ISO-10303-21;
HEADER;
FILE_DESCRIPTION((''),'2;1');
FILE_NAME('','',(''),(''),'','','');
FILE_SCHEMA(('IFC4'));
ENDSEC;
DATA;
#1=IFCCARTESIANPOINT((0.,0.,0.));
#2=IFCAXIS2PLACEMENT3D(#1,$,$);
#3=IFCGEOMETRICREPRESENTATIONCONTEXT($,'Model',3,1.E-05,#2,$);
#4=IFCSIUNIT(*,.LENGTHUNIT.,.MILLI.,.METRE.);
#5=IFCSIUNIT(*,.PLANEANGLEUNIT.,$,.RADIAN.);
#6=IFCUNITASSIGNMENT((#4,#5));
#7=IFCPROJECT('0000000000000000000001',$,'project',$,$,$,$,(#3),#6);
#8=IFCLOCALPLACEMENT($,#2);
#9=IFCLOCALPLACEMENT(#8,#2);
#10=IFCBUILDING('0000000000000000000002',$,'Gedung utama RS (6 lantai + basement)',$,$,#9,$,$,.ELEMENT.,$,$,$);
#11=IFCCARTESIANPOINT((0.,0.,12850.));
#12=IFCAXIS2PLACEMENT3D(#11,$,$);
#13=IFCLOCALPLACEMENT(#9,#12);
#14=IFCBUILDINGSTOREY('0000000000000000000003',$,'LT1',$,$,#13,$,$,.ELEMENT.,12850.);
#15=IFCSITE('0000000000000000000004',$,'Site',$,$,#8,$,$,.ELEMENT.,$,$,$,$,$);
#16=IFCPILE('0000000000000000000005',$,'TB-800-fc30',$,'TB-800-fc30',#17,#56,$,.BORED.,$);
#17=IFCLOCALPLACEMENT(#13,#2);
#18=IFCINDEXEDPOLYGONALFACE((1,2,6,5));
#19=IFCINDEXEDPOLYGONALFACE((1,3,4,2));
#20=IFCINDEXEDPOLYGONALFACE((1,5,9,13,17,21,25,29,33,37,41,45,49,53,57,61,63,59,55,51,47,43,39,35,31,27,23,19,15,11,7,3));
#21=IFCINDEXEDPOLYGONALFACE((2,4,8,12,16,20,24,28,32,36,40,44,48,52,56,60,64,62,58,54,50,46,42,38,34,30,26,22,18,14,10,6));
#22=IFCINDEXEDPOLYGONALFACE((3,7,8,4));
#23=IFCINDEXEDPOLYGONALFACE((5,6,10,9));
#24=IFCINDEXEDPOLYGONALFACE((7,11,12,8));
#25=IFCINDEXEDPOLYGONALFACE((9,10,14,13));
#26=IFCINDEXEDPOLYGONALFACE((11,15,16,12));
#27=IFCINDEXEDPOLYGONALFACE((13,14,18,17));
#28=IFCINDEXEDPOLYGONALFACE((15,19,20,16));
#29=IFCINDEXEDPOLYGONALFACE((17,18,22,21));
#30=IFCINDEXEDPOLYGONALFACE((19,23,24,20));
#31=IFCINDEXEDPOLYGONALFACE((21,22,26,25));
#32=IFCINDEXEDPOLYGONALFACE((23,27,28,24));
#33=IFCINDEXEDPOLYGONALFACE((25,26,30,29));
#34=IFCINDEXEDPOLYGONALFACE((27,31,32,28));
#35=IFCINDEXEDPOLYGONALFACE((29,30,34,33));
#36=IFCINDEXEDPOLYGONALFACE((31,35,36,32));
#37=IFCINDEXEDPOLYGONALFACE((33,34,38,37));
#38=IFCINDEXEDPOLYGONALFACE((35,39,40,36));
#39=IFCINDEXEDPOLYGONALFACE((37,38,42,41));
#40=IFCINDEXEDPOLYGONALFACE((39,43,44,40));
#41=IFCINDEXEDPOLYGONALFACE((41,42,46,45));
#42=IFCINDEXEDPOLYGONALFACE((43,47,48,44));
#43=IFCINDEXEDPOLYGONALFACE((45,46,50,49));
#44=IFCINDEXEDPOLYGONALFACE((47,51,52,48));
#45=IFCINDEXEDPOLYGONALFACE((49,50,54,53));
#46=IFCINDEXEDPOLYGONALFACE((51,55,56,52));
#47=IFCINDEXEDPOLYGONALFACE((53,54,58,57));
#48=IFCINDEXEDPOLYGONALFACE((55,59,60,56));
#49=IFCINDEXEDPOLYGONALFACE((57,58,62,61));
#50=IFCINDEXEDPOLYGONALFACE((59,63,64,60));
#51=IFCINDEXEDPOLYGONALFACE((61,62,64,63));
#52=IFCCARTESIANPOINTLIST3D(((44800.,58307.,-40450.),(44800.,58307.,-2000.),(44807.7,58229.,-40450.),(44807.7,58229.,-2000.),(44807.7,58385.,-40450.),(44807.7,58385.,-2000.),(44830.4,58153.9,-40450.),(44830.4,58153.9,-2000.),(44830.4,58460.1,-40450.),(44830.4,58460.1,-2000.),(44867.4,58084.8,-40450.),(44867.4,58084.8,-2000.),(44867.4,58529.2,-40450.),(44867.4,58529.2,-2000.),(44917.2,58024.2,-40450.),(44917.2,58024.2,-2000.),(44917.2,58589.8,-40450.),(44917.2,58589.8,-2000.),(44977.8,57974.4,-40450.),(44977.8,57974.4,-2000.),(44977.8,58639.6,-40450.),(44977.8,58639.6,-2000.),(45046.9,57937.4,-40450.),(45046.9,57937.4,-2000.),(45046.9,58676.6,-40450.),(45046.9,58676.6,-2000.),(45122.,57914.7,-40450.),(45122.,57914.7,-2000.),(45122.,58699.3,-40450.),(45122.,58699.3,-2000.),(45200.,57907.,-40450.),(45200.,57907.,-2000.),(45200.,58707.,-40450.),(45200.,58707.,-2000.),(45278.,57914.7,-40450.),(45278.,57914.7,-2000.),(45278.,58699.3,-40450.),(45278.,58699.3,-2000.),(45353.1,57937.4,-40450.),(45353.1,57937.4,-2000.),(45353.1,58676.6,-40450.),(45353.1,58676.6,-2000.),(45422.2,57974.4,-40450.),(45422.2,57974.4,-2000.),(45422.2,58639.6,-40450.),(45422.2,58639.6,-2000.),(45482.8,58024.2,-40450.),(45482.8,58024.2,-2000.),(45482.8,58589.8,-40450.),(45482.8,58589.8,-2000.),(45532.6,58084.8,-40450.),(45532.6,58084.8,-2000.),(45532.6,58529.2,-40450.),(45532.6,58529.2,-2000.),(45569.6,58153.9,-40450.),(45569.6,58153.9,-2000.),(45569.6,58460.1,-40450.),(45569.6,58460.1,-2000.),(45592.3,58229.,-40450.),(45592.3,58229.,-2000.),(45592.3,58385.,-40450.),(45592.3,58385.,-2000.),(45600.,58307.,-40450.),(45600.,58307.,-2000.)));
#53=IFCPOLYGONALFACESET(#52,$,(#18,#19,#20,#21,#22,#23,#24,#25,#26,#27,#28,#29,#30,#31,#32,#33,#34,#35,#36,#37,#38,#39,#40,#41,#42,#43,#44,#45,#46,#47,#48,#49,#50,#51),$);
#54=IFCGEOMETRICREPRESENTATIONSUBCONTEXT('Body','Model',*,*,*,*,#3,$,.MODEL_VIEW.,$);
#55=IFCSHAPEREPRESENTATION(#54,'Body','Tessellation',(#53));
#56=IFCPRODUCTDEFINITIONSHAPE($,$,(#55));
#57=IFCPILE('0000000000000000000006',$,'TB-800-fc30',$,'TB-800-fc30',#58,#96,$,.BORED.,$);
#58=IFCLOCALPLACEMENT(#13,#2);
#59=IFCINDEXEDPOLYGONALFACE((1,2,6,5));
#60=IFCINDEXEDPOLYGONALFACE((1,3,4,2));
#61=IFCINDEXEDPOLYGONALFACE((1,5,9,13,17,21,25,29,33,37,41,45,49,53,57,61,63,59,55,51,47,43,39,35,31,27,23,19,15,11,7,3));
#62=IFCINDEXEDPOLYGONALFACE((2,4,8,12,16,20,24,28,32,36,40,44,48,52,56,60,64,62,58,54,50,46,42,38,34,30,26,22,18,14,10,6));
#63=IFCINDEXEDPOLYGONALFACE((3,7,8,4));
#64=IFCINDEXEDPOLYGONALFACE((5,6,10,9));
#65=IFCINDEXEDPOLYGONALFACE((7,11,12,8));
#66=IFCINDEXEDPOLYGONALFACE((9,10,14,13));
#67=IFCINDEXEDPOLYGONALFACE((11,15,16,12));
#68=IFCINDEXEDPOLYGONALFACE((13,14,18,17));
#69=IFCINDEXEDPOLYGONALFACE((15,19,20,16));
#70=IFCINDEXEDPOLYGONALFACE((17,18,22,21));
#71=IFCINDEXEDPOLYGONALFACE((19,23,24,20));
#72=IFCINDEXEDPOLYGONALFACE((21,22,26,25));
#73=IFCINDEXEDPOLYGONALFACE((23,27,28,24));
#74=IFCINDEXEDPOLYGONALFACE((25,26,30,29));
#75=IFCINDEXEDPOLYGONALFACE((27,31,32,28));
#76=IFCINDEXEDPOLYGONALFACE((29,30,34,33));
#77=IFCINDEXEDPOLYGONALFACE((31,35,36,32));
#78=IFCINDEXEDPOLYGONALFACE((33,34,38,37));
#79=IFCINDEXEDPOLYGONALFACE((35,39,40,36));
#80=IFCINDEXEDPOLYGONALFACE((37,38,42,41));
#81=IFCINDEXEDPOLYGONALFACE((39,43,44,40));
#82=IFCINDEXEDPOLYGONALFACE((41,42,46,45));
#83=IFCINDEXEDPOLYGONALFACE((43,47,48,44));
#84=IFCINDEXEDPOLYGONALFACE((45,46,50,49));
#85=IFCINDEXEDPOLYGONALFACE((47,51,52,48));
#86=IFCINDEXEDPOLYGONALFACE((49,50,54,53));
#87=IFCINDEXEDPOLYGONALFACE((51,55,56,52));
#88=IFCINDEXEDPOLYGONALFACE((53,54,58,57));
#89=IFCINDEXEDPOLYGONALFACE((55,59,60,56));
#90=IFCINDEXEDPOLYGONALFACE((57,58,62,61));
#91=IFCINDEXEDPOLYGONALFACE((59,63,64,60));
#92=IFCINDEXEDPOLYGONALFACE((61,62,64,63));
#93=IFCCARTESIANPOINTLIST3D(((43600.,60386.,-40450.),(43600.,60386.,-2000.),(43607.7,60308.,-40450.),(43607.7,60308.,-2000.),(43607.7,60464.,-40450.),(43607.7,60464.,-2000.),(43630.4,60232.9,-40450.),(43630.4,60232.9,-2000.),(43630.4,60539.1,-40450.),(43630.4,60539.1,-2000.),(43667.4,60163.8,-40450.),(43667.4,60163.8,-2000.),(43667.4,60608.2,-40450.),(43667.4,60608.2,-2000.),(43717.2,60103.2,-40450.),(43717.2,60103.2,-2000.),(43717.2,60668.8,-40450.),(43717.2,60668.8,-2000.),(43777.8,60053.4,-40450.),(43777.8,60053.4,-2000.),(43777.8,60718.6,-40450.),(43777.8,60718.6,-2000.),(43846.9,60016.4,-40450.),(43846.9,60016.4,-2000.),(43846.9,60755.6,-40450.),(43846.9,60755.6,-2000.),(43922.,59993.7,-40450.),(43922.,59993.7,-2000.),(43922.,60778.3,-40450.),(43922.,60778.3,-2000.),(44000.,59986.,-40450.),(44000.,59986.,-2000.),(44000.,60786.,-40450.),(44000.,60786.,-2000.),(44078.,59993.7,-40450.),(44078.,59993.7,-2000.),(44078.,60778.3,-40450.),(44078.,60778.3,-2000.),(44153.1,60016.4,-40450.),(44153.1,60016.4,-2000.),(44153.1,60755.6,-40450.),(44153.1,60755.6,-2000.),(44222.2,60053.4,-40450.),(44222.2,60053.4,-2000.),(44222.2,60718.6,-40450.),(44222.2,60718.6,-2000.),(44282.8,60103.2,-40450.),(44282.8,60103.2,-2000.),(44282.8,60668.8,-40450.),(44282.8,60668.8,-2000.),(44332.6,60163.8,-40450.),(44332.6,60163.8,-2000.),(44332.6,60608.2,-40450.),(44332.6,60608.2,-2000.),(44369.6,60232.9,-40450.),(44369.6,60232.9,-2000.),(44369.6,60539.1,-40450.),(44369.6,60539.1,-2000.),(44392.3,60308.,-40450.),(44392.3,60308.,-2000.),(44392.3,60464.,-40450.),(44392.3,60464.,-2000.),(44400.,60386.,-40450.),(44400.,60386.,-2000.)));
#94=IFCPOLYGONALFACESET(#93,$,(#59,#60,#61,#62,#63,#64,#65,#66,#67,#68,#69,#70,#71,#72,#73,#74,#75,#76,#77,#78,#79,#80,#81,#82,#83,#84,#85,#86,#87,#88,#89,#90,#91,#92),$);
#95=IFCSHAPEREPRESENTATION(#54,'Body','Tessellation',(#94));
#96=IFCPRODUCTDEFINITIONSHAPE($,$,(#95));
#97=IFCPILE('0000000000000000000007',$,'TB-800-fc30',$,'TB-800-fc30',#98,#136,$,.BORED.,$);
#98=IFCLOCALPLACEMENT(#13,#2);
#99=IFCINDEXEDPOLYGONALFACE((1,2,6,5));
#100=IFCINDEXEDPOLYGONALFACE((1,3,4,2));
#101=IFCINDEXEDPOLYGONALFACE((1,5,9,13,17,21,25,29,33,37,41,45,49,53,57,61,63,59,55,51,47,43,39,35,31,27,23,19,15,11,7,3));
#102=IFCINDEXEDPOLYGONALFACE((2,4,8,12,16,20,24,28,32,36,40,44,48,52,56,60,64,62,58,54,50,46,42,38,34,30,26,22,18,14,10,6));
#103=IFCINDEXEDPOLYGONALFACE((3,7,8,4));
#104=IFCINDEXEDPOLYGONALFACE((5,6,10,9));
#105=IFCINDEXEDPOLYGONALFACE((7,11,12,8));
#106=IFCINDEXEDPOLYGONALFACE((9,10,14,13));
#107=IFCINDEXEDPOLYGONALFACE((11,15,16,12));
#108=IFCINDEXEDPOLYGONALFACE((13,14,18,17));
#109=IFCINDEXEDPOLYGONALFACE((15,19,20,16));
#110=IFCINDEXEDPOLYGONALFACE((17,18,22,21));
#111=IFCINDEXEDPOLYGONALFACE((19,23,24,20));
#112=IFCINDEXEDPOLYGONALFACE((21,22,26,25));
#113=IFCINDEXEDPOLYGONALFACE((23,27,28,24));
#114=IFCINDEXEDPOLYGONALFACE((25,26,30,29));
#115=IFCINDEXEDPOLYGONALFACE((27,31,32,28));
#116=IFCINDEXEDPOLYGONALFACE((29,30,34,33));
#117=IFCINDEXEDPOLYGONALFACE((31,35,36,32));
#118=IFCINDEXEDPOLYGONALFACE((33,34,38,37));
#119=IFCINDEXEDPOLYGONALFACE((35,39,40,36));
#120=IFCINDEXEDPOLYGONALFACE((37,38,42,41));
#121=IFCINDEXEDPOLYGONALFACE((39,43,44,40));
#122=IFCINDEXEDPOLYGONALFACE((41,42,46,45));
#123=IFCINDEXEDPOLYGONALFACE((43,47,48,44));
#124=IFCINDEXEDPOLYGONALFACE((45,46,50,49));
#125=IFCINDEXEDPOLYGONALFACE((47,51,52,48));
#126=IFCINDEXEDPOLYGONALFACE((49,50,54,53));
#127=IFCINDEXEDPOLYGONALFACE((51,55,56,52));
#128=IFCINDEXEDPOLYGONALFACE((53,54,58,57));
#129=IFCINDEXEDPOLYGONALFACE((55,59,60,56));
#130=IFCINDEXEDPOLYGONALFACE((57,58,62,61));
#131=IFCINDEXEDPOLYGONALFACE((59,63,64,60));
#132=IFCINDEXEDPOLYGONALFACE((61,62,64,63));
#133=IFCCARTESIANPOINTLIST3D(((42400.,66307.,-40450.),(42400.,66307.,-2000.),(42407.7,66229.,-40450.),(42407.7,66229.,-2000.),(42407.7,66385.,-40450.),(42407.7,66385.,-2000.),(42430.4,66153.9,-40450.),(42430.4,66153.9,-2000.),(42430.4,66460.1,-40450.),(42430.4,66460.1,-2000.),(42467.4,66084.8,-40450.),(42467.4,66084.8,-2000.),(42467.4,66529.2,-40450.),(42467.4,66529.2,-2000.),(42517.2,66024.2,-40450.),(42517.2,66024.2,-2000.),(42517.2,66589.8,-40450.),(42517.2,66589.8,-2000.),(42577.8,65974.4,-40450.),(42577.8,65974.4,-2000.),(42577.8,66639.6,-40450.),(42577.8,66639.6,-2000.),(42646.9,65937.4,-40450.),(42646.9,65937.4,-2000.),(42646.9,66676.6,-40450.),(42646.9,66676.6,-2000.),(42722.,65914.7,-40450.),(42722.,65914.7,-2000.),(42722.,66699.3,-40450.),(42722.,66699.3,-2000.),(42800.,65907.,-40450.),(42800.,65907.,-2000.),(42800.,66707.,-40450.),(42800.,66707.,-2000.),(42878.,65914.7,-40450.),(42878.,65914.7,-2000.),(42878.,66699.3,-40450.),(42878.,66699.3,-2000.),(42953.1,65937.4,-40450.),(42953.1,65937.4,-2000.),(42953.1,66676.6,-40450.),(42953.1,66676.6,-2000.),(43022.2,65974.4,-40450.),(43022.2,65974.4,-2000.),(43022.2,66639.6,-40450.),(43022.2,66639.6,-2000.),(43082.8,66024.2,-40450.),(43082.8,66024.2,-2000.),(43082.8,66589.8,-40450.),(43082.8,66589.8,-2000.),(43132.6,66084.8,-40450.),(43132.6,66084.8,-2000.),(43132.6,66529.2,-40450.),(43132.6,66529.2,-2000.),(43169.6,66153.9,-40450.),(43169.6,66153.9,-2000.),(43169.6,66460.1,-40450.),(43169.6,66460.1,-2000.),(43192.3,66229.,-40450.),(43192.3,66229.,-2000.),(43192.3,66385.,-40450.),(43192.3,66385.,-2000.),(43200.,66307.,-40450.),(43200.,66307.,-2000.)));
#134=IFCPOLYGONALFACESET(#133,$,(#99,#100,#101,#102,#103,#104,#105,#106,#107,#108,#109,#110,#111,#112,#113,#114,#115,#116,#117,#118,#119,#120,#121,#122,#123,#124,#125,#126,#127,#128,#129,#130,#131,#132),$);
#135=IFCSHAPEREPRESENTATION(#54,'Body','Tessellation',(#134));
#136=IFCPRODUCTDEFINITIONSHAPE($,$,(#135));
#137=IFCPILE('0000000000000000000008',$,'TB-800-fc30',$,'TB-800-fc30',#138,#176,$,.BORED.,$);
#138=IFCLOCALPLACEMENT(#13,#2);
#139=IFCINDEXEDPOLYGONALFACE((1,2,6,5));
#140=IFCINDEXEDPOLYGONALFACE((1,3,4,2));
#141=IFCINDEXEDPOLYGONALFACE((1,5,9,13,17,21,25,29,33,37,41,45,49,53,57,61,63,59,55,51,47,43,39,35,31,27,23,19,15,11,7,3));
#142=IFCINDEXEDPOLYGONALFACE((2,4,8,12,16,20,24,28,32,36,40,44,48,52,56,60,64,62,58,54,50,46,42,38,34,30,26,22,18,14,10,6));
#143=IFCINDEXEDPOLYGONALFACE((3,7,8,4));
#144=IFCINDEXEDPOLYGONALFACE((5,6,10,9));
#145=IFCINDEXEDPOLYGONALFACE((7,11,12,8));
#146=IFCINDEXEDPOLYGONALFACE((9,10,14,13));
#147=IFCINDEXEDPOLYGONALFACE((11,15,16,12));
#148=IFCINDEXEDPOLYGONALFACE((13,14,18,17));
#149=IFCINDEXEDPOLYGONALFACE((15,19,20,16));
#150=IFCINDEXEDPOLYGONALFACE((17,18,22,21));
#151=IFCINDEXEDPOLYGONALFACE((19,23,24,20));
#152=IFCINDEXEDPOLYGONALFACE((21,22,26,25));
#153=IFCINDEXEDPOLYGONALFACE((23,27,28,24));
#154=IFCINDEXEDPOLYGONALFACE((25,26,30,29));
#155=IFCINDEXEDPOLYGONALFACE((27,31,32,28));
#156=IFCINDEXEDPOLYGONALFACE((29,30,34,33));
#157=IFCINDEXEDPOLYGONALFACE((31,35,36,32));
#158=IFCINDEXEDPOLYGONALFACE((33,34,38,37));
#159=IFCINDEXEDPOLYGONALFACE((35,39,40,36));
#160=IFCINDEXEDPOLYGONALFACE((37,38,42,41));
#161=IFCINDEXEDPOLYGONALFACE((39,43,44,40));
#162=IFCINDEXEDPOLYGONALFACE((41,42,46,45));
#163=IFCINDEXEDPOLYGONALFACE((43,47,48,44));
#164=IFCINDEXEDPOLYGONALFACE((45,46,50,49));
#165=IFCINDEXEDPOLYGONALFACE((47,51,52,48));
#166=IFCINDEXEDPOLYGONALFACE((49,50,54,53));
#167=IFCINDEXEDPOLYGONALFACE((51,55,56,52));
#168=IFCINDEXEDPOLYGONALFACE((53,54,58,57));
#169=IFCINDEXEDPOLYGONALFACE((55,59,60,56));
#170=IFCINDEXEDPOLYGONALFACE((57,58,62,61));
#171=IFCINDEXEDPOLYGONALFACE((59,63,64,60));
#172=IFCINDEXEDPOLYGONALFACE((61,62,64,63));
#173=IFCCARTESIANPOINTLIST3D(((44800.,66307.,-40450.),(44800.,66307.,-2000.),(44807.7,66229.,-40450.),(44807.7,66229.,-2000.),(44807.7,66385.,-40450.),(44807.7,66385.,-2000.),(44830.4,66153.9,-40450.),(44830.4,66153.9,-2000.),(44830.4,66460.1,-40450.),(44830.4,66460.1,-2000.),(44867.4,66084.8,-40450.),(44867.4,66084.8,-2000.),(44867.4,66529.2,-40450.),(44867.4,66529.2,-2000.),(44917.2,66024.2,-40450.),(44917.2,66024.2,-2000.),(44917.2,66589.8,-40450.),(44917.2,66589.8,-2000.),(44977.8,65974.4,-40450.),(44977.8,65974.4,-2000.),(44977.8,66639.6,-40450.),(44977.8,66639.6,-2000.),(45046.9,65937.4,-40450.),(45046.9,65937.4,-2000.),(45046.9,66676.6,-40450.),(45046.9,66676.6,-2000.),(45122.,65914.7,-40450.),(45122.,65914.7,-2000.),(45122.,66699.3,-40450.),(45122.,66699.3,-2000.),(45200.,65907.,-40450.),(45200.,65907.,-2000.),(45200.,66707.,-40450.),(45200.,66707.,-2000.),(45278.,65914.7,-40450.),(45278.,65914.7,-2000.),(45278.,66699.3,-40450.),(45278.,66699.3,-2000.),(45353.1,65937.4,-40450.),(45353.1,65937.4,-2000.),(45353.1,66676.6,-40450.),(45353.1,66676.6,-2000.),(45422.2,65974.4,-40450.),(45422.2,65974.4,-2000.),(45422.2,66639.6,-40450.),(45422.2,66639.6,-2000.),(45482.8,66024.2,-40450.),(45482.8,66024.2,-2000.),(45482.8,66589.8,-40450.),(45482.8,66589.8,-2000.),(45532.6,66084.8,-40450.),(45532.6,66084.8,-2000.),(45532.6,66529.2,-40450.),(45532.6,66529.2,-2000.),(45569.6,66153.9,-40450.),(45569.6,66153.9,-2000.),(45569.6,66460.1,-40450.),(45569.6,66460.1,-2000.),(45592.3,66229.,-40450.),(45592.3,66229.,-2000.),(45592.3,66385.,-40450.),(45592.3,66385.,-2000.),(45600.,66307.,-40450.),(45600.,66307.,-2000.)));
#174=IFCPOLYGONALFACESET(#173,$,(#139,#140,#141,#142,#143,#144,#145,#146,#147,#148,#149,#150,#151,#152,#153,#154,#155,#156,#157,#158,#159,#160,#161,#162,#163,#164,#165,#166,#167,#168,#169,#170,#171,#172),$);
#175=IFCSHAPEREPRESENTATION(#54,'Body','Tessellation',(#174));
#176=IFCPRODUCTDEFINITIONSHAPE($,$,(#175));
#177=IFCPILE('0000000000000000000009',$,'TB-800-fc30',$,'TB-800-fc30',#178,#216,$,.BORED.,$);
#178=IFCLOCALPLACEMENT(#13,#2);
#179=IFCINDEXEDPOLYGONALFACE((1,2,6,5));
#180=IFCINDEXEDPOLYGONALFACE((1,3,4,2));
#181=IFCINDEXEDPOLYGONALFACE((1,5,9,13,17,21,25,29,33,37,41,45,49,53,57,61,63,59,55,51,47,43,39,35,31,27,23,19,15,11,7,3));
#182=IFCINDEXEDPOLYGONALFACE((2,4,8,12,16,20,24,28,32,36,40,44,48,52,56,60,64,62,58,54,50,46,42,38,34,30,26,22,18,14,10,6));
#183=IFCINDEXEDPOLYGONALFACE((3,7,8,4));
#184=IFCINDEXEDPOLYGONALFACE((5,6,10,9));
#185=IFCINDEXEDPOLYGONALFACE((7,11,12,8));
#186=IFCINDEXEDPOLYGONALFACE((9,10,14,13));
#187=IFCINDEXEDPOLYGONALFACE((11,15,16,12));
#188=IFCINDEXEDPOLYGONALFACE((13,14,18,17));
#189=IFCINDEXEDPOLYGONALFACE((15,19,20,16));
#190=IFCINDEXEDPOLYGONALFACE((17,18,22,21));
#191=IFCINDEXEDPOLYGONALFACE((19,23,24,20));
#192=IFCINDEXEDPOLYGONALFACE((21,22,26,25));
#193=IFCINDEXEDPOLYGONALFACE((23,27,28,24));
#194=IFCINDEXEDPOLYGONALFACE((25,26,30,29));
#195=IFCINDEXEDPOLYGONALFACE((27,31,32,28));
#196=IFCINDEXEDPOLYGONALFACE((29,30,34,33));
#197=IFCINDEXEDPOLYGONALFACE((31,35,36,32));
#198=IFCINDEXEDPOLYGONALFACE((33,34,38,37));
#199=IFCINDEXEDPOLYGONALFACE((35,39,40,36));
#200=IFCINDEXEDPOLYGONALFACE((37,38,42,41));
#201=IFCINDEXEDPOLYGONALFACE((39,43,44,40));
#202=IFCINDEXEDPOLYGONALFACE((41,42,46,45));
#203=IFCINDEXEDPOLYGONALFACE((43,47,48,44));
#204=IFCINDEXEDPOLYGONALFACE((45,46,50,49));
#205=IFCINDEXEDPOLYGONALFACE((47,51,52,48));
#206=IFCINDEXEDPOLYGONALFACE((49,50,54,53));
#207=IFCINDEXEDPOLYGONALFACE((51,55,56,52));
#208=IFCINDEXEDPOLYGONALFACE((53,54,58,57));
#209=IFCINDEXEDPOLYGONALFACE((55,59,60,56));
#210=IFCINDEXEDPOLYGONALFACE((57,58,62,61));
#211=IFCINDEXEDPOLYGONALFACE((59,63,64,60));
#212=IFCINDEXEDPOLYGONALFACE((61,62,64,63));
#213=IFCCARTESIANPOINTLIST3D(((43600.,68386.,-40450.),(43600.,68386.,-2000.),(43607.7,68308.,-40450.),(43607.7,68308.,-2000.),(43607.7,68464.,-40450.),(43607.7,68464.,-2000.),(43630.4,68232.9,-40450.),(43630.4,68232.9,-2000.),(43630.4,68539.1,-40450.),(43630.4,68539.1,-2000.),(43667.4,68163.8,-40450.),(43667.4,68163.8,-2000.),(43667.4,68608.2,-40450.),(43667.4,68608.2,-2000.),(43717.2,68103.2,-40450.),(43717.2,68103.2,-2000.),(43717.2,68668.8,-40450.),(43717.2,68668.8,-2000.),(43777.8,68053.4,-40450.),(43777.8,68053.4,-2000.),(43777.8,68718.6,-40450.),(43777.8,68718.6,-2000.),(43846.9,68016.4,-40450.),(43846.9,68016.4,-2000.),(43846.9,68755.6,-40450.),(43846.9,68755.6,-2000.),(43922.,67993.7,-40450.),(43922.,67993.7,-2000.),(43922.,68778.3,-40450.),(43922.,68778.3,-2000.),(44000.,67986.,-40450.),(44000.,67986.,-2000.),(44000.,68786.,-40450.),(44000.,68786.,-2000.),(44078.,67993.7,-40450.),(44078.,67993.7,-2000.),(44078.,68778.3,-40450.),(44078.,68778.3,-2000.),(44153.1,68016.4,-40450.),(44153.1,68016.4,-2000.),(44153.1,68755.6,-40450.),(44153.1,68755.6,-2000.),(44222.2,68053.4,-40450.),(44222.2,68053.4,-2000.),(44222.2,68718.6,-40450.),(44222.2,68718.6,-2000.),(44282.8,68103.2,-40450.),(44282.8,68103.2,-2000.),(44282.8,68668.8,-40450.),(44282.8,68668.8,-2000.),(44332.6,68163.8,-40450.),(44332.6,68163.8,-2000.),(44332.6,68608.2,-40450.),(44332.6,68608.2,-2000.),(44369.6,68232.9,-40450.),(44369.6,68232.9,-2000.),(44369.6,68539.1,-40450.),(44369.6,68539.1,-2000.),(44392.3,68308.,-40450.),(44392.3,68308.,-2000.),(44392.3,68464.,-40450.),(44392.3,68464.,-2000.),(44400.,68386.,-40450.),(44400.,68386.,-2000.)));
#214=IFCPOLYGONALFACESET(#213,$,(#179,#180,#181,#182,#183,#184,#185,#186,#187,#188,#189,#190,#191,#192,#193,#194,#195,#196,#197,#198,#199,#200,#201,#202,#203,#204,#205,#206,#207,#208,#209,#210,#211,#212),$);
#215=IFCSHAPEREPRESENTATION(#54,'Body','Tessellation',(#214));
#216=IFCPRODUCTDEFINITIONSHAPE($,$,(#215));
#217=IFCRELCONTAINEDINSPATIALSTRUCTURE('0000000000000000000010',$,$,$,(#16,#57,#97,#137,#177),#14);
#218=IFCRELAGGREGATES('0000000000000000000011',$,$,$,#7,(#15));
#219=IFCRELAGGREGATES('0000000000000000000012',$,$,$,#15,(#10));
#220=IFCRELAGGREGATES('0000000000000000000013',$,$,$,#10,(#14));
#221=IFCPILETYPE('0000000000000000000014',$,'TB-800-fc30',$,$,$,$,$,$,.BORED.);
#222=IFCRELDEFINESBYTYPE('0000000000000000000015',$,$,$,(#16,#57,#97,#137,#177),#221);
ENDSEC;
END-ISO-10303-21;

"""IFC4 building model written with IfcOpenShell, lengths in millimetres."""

from ifc_helpers import new_model, si_unit, frame, origin, origin_2d, place, context, subcontext, project, spatial, circle, extrude, material_profile, profile_set, profile_usage, type_object, element, save


model = new_model("IFC4")

# Units and contexts
model_context = context("Model", 3, precision=1e-05, world=origin())
body_context = subcontext(model_context, "Body", "Model", "MODEL_VIEW")
ifc_project = project(units=[si_unit("LENGTHUNIT", "METRE", prefix="MILLI"), si_unit("PLANEANGLEUNIT", "RADIAN")], contexts=[model_context])

# Site, building, storey
site_placement = place(None, origin())
site = spatial("IfcSite", under=ifc_project, at=site_placement, Name="Site", CompositionType="ELEMENT")
building_placement = place(site_placement, origin())
building = spatial("IfcBuilding", under=site, at=building_placement, Name="Gedung utama RS (6 lantai + basement)", CompositionType="ELEMENT")
storey_placement = place(building_placement, frame((0.0, 0.0, 12850.0)))
storey = spatial("IfcBuildingStorey", under=building, at=storey_placement, Name="LT1", CompositionType="ELEMENT", Elevation=12850.0)

# Piles
ifc_material_profile = material_profile(None, circle(Radius=400.0, at=origin_2d()), Name="TB-800-fc30")
ifc_profile_set = profile_set([ifc_material_profile], Name="TB-800-fc30")
ifc_profile_usage = profile_usage(ifc_profile_set, cardinal=5)
pile_type = type_object("IfcPileType", Name="TB-800-fc30", PredefinedType="BORED", material=ifc_profile_set)
for number, where, z_axis, x_axis, name in (
    (1, (45200.0, 58307.0, -40450.0), (0.0, 0.0, 1.0), (1.0, 0.0, 0.0), "TB-800-fc30"),
    (2, (44000.0, 60386.0, -40450.0), (0.0, 0.0, 1.0), (1.0, 0.0, 0.0), "TB-800-fc30"),
    (3, (42800.0, 66307.0, -40450.0), (0.0, 0.0, 1.0), (1.0, 0.0, 0.0), "TB-800-fc30"),
    (4, (45200.0, 66307.0, -40450.0), (0.0, 0.0, 1.0), (1.0, 0.0, 0.0), "TB-800-fc30"),
    (5, (44000.0, 68386.0, -40450.0), (0.0, 0.0, 1.0), (1.0, 0.0, 0.0), "TB-800-fc30"),
):
    element("IfcPile", number, at=place(storey_placement, frame(where, z_axis=z_axis, x_axis=x_axis)), inside=storey, type_object=pile_type, material=ifc_profile_usage, Name=name, ObjectType="TB-800-fc30", PredefinedType="BORED", context=body_context, shape_type="SweptSolid", body=[
        extrude(circle(Radius=400.0, at=origin_2d()), origin(), (0.0, 0.0, 1.0), 38450.0),
    ])

save(model, "model.ifc")
